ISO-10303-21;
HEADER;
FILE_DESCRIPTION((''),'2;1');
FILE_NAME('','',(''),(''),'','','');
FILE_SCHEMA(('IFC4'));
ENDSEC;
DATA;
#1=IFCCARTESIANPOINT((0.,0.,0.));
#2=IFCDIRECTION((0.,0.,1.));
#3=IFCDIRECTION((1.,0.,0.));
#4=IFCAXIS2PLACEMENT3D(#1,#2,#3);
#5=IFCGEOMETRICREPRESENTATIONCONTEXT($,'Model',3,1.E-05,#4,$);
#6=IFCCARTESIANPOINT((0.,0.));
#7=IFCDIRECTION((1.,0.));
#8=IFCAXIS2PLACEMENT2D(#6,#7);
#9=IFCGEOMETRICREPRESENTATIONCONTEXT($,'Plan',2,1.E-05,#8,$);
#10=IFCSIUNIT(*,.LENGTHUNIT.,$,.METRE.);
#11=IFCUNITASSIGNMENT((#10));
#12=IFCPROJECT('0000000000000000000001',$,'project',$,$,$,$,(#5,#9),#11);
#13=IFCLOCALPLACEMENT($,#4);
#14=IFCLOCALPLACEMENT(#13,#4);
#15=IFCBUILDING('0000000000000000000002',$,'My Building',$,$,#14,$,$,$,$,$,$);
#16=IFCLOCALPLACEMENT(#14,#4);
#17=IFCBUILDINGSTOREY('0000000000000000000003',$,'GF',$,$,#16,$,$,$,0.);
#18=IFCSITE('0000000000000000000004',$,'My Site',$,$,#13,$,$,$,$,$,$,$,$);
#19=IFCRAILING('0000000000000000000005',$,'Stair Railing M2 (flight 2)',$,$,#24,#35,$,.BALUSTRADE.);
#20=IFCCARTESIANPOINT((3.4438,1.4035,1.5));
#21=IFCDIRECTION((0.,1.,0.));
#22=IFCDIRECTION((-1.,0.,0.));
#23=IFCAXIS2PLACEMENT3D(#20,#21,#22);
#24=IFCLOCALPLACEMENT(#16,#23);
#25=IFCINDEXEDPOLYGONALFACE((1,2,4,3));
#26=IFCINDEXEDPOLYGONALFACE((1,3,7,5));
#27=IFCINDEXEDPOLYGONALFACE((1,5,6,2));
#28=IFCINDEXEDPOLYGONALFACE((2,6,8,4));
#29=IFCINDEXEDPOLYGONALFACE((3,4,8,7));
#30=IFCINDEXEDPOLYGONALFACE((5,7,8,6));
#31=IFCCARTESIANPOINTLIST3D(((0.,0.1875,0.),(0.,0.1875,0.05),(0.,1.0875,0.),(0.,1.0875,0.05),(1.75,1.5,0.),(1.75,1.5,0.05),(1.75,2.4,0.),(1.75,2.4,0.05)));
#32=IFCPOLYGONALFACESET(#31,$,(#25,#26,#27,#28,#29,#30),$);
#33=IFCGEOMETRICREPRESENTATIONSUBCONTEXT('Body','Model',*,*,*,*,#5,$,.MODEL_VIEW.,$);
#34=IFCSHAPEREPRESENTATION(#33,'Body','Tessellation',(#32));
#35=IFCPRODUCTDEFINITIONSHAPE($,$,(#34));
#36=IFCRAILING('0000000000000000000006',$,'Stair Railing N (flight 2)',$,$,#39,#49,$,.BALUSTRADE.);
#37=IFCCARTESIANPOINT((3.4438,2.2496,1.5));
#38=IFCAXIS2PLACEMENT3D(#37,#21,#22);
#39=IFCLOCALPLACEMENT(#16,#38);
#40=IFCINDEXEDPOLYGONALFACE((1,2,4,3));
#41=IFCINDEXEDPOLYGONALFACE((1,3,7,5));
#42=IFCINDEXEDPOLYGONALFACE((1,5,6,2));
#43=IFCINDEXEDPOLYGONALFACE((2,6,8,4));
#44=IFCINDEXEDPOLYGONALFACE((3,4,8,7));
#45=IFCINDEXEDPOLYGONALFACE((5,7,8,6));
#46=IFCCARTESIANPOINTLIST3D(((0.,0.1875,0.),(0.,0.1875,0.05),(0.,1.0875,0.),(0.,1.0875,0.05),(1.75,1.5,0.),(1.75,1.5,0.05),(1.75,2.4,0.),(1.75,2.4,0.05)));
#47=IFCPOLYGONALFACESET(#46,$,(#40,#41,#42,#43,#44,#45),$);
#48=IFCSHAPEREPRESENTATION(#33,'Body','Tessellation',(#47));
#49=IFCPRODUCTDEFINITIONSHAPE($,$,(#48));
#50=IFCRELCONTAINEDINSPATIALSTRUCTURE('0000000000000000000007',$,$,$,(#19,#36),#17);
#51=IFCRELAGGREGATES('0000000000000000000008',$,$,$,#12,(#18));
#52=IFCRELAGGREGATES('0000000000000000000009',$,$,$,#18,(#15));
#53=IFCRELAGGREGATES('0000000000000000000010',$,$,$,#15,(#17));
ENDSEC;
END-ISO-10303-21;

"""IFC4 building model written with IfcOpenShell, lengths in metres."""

from ifc_helpers import new_model, si_unit, frame, origin_with_axes, origin_2d_with_axis, place, context, subcontext, project, spatial, polyline, outline, extrude, element, save


model = new_model("IFC4")

# Units and contexts
model_context = context("Model", 3, precision=1e-05, world=origin_with_axes())
plan_context = context("Plan", 2, precision=1e-05, world=origin_2d_with_axis())
body_context_1 = subcontext(model_context, "Body", "Model", "MODEL_VIEW")
ifc_project = project(units=[si_unit("LENGTHUNIT", "METRE")], contexts=[model_context, plan_context])

# Site, building, storey
site_placement = place(None, origin_with_axes())
site = spatial("IfcSite", under=ifc_project, at=site_placement, Name="My Site")
building_placement = place(site_placement, origin_with_axes())
building = spatial("IfcBuilding", under=site, at=building_placement, Name="My Building")
storey_placement = place(building_placement, origin_with_axes())
storey = spatial("IfcBuildingStorey", under=building, at=storey_placement, Name="GF", Elevation=0.0)

# Railings
for number, where, z_axis, x_axis, name in (
    (1, (3.4438, 1.4035, 1.5), (0.0, 1.0, 0.0), (-1.0, 0.0, 0.0), "Stair Railing M2 (flight 2)"),
):
    element("IfcRailing", number, at=place(storey_placement, frame(where, z_axis=z_axis, x_axis=x_axis)), inside=storey, Name=name, PredefinedType="BALUSTRADE", context=body_context_1, shape_type="SweptSolid", body=[
        extrude(outline(polyline([(0.0, 0.1875), (1.75, 1.5), (1.75, 2.4), (0.0, 1.0875), (0.0, 0.1875)])), origin_with_axes(), (0.0, 0.0, 1.0), 0.05),
    ])
railing_1_placement = place(storey_placement, frame((3.4438, 2.2496, 1.5), z_axis=(0.0, 1.0, 0.0), x_axis=(-1.0, 0.0, 0.0)))
element("IfcRailing", 2, at=railing_1_placement, inside=storey, Name="Stair Railing N (flight 2)", PredefinedType="BALUSTRADE", context=body_context_1, shape_type="SweptSolid", body=[
    extrude(outline(polyline([(0.0, 0.1875), (1.75, 1.5), (1.75, 2.4), (0.0, 1.0875), (0.0, 0.1875)])), origin_with_axes(), (0.0, 0.0, 1.0), 0.05),
])

save(model, "model.ifc")
